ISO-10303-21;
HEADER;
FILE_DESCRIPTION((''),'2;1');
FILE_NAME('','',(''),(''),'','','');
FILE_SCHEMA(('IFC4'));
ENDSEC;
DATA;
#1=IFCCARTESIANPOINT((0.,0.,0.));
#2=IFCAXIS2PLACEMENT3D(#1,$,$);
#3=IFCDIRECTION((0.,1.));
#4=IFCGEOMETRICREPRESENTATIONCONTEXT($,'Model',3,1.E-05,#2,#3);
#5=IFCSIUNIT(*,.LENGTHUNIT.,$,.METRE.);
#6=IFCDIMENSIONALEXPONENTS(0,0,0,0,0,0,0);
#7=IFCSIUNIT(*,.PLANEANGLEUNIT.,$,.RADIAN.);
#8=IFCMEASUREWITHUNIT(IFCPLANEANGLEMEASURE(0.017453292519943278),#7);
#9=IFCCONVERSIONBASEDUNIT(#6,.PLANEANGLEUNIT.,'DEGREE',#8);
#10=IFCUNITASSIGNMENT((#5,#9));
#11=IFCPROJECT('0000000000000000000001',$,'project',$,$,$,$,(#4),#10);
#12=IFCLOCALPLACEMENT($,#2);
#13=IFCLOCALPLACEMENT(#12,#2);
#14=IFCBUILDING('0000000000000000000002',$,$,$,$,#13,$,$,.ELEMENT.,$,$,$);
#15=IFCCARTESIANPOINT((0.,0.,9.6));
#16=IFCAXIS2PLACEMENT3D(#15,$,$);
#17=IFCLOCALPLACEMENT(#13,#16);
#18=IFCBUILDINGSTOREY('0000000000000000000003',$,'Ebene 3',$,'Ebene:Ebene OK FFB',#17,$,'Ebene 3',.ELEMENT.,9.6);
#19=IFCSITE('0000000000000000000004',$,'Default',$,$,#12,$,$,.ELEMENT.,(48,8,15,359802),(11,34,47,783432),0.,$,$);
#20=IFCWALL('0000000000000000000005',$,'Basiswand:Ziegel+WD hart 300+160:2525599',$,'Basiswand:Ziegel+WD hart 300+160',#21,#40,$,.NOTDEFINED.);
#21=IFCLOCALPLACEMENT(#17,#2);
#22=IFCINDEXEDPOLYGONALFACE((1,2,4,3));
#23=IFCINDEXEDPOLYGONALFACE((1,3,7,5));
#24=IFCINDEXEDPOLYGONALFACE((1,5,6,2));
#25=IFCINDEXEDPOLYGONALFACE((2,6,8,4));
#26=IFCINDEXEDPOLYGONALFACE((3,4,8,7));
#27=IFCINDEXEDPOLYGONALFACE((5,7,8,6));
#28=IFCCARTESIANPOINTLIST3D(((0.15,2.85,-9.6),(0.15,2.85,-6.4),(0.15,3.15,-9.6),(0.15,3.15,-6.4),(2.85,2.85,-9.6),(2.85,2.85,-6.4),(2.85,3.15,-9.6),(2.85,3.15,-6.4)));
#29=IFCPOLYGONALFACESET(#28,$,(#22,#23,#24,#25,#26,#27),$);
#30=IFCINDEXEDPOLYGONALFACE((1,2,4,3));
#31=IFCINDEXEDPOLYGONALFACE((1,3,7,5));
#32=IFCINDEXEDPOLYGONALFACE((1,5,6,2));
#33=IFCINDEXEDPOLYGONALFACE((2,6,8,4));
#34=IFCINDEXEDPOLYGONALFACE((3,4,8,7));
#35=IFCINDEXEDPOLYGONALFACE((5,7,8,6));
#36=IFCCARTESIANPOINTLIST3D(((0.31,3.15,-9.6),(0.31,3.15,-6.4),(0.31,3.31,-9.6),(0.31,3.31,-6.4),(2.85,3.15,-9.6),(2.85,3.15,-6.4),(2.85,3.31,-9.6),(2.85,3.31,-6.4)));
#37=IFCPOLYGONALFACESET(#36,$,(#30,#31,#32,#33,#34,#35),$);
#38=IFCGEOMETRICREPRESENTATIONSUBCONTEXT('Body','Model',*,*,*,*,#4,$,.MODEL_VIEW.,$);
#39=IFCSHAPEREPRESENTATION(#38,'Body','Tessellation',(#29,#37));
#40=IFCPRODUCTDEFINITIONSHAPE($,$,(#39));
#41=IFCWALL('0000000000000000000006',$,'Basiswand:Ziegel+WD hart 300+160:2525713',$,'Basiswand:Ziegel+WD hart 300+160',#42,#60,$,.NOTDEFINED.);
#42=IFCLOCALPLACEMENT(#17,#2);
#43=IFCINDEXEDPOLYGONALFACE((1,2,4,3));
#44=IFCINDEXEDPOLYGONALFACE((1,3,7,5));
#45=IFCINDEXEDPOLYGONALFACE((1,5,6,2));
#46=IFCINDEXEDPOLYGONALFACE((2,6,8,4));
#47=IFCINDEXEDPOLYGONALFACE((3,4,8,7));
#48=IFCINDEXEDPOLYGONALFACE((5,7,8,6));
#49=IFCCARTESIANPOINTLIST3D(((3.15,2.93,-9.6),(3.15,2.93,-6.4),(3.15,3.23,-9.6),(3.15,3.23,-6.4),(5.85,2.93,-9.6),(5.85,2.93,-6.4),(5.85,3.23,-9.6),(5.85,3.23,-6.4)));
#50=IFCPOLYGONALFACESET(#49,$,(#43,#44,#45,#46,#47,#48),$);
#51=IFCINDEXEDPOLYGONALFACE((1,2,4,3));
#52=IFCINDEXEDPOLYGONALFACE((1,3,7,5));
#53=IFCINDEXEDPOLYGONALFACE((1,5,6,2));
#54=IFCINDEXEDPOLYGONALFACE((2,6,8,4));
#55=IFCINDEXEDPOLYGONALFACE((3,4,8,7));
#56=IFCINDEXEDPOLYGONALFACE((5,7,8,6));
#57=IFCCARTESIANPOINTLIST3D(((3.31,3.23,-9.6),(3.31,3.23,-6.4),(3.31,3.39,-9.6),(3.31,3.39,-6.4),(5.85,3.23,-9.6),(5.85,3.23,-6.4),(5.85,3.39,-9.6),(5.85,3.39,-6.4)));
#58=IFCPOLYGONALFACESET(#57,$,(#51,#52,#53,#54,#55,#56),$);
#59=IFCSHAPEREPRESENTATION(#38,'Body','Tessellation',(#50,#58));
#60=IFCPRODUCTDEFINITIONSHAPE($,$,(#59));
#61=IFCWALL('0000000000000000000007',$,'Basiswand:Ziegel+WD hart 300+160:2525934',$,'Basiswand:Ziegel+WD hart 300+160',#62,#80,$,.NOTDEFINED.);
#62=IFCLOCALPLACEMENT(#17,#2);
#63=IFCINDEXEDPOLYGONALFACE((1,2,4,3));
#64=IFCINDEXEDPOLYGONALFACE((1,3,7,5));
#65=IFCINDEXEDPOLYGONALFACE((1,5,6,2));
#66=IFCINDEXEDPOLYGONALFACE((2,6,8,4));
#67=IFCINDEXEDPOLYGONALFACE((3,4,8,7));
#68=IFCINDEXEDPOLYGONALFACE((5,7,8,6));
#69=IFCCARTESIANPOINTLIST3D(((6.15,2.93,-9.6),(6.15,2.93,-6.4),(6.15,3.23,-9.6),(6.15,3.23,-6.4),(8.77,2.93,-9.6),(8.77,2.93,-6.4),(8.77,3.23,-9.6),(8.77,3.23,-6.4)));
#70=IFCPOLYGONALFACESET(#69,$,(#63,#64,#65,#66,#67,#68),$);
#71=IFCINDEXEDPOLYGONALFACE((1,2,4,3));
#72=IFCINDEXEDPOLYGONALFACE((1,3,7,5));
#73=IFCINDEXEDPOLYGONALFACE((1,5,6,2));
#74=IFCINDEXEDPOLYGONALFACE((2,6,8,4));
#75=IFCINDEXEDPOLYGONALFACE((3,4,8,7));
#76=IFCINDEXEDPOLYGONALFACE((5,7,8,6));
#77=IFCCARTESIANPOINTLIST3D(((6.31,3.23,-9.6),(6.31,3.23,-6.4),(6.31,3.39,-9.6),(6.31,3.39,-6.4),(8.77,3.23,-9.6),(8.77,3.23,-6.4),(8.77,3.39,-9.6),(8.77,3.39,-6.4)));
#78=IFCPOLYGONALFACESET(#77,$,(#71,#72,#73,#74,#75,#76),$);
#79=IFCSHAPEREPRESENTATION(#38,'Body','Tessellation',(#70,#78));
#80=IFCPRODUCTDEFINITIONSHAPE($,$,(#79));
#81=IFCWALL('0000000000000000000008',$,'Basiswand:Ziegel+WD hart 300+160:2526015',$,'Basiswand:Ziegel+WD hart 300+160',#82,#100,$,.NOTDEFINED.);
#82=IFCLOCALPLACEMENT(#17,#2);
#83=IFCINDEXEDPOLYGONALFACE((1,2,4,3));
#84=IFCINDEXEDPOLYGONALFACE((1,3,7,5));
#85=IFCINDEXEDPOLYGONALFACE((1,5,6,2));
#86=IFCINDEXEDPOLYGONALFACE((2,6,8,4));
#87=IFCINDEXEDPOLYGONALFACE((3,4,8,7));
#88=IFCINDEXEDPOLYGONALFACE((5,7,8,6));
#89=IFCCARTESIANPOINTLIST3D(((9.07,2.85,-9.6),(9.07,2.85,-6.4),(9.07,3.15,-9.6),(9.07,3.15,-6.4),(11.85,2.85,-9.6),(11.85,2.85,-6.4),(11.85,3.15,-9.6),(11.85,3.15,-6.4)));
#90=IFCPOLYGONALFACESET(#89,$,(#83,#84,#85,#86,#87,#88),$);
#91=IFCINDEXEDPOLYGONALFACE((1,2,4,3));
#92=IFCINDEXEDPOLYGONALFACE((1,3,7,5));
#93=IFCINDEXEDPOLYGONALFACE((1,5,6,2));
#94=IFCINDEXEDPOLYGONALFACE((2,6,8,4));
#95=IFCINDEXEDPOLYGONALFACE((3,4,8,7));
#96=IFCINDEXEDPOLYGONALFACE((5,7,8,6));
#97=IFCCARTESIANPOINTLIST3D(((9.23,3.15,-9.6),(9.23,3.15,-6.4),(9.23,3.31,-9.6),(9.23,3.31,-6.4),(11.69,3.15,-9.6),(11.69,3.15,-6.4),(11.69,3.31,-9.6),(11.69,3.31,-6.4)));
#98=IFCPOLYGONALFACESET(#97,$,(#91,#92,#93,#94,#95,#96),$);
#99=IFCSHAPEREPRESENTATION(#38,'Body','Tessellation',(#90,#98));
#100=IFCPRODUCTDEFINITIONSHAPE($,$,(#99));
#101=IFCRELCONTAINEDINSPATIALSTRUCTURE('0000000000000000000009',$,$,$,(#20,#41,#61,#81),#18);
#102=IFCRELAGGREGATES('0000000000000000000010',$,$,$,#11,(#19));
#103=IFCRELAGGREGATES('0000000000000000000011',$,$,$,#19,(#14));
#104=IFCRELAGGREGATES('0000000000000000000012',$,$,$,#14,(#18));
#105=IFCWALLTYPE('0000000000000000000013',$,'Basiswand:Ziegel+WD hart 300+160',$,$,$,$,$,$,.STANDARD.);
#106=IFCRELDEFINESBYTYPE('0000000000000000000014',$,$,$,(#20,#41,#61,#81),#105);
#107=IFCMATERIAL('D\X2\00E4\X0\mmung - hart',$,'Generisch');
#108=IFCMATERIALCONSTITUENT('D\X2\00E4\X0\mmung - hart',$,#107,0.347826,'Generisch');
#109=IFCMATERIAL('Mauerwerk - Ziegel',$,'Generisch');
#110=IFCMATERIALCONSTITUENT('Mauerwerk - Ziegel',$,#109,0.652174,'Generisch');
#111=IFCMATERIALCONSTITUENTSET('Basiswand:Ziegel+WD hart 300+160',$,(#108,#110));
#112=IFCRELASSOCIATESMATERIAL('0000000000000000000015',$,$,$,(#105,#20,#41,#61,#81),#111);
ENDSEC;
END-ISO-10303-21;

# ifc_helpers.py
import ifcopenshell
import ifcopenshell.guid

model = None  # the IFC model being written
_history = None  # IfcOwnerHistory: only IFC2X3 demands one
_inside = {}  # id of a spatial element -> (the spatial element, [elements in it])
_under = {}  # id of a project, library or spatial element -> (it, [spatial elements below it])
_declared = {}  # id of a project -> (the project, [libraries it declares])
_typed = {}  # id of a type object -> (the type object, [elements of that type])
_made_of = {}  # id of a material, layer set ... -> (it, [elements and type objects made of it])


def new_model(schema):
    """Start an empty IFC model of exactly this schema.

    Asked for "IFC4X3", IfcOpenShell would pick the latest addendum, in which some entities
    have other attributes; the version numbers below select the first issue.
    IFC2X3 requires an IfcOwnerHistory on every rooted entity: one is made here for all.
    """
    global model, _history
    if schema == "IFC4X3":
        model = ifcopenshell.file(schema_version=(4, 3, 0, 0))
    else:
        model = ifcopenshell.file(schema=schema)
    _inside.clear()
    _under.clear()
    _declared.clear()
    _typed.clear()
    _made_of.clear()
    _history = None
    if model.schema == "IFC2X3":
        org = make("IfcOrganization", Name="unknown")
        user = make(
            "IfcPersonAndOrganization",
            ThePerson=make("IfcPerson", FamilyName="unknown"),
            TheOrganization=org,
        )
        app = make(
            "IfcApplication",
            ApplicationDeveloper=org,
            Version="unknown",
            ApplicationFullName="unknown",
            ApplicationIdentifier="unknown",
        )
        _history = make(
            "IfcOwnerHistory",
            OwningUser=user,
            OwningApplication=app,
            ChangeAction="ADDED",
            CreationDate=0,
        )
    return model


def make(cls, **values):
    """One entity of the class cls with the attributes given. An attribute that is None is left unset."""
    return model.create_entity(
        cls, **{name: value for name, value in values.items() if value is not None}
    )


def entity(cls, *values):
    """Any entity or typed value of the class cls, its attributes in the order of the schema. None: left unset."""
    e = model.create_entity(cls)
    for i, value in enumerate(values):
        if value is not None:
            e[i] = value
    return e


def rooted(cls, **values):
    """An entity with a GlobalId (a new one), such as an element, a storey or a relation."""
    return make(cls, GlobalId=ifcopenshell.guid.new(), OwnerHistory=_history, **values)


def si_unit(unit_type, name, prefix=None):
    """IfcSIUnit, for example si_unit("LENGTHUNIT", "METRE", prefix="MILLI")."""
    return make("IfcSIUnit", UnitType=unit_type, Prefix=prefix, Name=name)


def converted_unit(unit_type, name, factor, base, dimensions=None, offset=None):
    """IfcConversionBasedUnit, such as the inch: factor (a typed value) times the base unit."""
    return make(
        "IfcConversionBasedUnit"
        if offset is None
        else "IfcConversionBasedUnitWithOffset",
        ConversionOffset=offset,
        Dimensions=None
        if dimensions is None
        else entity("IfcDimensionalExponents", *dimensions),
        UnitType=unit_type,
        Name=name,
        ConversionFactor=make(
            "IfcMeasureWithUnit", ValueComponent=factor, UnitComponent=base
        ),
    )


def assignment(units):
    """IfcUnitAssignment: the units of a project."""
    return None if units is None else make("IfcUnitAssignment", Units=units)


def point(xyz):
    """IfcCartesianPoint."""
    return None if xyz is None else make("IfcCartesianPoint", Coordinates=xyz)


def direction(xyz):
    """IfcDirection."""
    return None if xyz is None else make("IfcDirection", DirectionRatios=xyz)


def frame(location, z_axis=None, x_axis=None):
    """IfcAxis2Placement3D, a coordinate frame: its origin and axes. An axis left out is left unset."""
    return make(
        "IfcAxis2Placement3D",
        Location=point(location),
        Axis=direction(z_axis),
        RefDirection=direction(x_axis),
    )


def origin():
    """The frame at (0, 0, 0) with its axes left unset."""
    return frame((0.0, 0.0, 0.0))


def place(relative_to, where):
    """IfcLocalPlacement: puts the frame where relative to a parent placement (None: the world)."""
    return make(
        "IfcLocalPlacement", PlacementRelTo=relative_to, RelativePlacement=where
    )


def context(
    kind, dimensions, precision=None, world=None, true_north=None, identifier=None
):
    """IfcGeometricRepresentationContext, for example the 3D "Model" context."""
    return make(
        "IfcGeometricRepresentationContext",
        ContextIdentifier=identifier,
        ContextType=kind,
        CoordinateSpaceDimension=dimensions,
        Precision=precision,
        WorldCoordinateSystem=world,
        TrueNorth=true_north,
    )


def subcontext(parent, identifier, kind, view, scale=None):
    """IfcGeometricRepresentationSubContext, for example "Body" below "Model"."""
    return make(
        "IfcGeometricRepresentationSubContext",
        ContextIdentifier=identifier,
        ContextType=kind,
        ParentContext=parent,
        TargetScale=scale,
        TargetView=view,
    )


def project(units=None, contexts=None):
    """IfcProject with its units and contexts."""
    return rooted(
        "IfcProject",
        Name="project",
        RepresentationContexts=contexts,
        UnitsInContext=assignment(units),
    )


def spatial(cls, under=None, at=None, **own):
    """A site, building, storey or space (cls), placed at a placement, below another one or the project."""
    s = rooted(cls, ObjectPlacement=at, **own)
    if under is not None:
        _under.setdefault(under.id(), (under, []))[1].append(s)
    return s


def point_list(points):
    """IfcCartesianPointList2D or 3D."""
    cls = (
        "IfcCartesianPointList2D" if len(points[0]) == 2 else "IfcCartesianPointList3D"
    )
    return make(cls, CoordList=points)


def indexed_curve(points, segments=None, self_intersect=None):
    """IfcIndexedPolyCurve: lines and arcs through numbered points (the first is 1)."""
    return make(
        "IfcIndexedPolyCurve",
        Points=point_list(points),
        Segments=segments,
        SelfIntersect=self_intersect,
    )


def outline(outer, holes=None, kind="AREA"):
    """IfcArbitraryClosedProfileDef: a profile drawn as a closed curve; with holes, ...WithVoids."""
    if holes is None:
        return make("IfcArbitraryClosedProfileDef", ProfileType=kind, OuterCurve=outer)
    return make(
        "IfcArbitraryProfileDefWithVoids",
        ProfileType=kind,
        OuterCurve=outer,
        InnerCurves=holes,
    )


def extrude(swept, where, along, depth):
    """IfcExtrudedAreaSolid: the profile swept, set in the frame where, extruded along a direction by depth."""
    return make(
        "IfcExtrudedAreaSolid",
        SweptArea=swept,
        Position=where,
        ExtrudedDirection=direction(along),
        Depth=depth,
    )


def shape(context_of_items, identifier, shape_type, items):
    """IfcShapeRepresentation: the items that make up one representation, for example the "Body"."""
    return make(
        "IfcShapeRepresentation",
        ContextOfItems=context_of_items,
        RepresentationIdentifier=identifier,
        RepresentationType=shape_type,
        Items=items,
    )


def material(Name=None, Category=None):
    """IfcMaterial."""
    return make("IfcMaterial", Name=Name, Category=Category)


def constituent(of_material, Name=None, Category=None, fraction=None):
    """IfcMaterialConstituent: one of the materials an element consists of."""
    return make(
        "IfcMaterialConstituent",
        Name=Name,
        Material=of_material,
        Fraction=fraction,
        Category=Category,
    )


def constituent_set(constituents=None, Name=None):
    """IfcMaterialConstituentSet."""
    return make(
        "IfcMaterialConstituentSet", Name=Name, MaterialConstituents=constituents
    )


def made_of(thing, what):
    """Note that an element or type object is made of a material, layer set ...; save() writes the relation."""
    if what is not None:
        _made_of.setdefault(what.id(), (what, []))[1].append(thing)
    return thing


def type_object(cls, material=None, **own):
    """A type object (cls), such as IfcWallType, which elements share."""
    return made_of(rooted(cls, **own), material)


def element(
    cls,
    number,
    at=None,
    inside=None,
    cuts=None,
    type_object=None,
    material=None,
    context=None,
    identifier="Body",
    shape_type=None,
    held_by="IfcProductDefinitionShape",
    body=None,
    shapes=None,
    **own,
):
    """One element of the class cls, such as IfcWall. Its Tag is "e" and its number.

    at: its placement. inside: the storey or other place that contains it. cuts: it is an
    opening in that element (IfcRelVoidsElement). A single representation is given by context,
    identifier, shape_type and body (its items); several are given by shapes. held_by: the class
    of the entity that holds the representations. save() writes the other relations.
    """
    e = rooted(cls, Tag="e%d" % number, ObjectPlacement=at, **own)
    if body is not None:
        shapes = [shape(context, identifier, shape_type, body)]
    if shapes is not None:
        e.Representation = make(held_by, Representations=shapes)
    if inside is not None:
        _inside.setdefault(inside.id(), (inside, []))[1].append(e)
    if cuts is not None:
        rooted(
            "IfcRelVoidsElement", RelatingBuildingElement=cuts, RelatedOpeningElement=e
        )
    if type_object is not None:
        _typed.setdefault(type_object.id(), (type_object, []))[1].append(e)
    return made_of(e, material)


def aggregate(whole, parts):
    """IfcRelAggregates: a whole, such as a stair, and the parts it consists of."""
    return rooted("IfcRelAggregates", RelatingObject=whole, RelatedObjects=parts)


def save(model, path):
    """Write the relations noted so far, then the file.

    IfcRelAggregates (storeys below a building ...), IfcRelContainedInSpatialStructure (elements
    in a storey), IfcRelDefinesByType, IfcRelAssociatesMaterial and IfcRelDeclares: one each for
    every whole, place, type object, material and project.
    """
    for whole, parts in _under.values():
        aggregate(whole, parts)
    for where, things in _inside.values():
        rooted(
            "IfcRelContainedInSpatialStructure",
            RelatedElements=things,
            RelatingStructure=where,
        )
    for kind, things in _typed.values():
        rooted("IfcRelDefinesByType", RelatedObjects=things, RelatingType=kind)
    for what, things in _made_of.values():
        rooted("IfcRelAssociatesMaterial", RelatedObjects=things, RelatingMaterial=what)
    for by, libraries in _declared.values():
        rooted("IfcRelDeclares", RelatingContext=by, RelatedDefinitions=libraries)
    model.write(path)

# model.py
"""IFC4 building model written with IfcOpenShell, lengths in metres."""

from ifc_helpers import new_model, entity, si_unit, converted_unit, direction, frame, origin, place, context, subcontext, project, spatial, indexed_curve, outline, extrude, material, constituent, constituent_set, type_object, element, save


model = new_model("IFC4")

# Units and contexts
model_context = context("Model", 3, precision=1e-05, world=origin(), true_north=direction((0.0, 1.0)))
body_context = subcontext(model_context, "Body", "Model", "MODEL_VIEW")
ifc_project = project(units=[si_unit("LENGTHUNIT", "METRE"), converted_unit("PLANEANGLEUNIT", "DEGREE", entity("IfcPlaneAngleMeasure", 0.017453292519943278), si_unit("PLANEANGLEUNIT", "RADIAN"), dimensions=[0, 0, 0, 0, 0, 0, 0])], contexts=[model_context])

# Site, building, storey
site_placement = place(None, origin())
site = spatial("IfcSite", under=ifc_project, at=site_placement, Name="Default", CompositionType="ELEMENT", RefLatitude=(48, 8, 15, 359802), RefLongitude=(11, 34, 47, 783432), RefElevation=0.0)
building_placement = place(site_placement, origin())
building = spatial("IfcBuilding", under=site, at=building_placement, CompositionType="ELEMENT")
storey_placement = place(building_placement, frame((0.0, 0.0, 9.6)))
storey = spatial("IfcBuildingStorey", under=building, at=storey_placement, Name="Ebene 3", ObjectType="Ebene:Ebene OK FFB", LongName="Ebene 3", CompositionType="ELEMENT", Elevation=9.6)

# Shared definitions
ifc_material_1 = material(Name="Dämmung - hart", Category="Generisch")
ifc_constituent_1 = constituent(ifc_material_1, Name="Dämmung - hart", Category="Generisch", fraction=0.347826)
ifc_material_2 = material(Name="Mauerwerk - Ziegel", Category="Generisch")
ifc_constituent_2 = constituent(ifc_material_2, Name="Mauerwerk - Ziegel", Category="Generisch", fraction=0.652174)
ifc_constituent_set = constituent_set(constituents=[ifc_constituent_1, ifc_constituent_2], Name="Basiswand:Ziegel+WD hart 300+160")
wall_type = type_object("IfcWallType", Name="Basiswand:Ziegel+WD hart 300+160", PredefinedType="STANDARD", material=ifc_constituent_set)

# Walls
wall_1_placement = place(storey_placement, frame((0.31, 3.08, -9.6)))
element("IfcWall", 1, at=wall_1_placement, inside=storey, type_object=wall_type, material=ifc_constituent_set, Name="Basiswand:Ziegel+WD hart 300+160:2525599", ObjectType="Basiswand:Ziegel+WD hart 300+160", PredefinedType="NOTDEFINED", context=body_context, shape_type="SweptSolid", body=[
    extrude(outline(indexed_curve([(-0.15, -1.35), (0.15, -1.35), (0.15, 1.35), (-0.15, 1.35), (-0.15, -1.35)], self_intersect=False)), frame((1.19, -0.08, 0.0), z_axis=(0.0, 0.0, 1.0), x_axis=(0.0, 1.0, 0.0)), (0.0, 0.0, 1.0), 3.2),
    extrude(outline(indexed_curve([(-0.08, -1.27), (0.08, -1.27), (0.08, 1.27), (-0.08, 1.27), (-0.08, -1.27)], self_intersect=False)), frame((1.27, 0.15, 0.0), z_axis=(0.0, 0.0, 1.0), x_axis=(0.0, -1.0, 0.0)), (0.0, 0.0, 1.0), 3.2),
])
wall_2_placement = place(storey_placement, frame((3.31, 3.16, -9.6)))
element("IfcWall", 2, at=wall_2_placement, inside=storey, type_object=wall_type, material=ifc_constituent_set, Name="Basiswand:Ziegel+WD hart 300+160:2525713", ObjectType="Basiswand:Ziegel+WD hart 300+160", PredefinedType="NOTDEFINED", context=body_context, shape_type="SweptSolid", body=[
    extrude(outline(indexed_curve([(-0.15, -1.35), (0.15, -1.35), (0.15, 1.35), (-0.15, 1.35), (-0.15, -1.35)], self_intersect=False)), frame((1.19, -0.08, 0.0), z_axis=(0.0, 0.0, 1.0), x_axis=(0.0, 1.0, 0.0)), (0.0, 0.0, 1.0), 3.2),
    extrude(outline(indexed_curve([(-0.08, -1.27), (0.08, -1.27), (0.08, 1.27), (-0.08, 1.27), (-0.08, -1.27)], self_intersect=False)), frame((1.27, 0.15, 0.0), z_axis=(0.0, 0.0, 1.0), x_axis=(0.0, -1.0, 0.0)), (0.0, 0.0, 1.0), 3.2),
])
wall_3_placement = place(storey_placement, frame((6.31, 3.16, -9.6)))
element("IfcWall", 3, at=wall_3_placement, inside=storey, type_object=wall_type, material=ifc_constituent_set, Name="Basiswand:Ziegel+WD hart 300+160:2525934", ObjectType="Basiswand:Ziegel+WD hart 300+160", PredefinedType="NOTDEFINED", context=body_context, shape_type="SweptSolid", body=[
    extrude(outline(indexed_curve([(-0.15, -1.31), (0.15, -1.31), (0.15, 1.31), (-0.15, 1.31), (-0.15, -1.31)], self_intersect=False)), frame((1.15, -0.08, 0.0), z_axis=(0.0, 0.0, 1.0), x_axis=(0.0, 1.0, 0.0)), (0.0, 0.0, 1.0), 3.2),
    extrude(outline(indexed_curve([(-0.08, -1.23), (0.08, -1.23), (0.08, 1.23), (-0.08, 1.23), (-0.08, -1.23)], self_intersect=False)), frame((1.23, 0.15, 0.0), z_axis=(0.0, 0.0, 1.0), x_axis=(0.0, -1.0, 0.0)), (0.0, 0.0, 1.0), 3.2),
])
wall_4_placement = place(storey_placement, frame((9.23, 3.08, -9.6)))
element("IfcWall", 4, at=wall_4_placement, inside=storey, type_object=wall_type, material=ifc_constituent_set, Name="Basiswand:Ziegel+WD hart 300+160:2526015", ObjectType="Basiswand:Ziegel+WD hart 300+160", PredefinedType="NOTDEFINED", context=body_context, shape_type="SweptSolid", body=[
    extrude(outline(indexed_curve([(-0.15, -1.39), (0.15, -1.39), (0.15, 1.39), (-0.15, 1.39), (-0.15, -1.39)], self_intersect=False)), frame((1.23, -0.08, 0.0), z_axis=(0.0, 0.0, 1.0), x_axis=(0.0, 1.0, 0.0)), (0.0, 0.0, 1.0), 3.2),
    extrude(outline(indexed_curve([(-0.08, -1.23), (0.08, -1.23), (0.08, 1.23), (-0.08, 1.23), (-0.08, -1.23)], self_intersect=False)), frame((1.23, 0.15, 0.0), z_axis=(0.0, 0.0, 1.0), x_axis=(0.0, -1.0, 0.0)), (0.0, 0.0, 1.0), 3.2),
])

save(model, "model.ifc")
